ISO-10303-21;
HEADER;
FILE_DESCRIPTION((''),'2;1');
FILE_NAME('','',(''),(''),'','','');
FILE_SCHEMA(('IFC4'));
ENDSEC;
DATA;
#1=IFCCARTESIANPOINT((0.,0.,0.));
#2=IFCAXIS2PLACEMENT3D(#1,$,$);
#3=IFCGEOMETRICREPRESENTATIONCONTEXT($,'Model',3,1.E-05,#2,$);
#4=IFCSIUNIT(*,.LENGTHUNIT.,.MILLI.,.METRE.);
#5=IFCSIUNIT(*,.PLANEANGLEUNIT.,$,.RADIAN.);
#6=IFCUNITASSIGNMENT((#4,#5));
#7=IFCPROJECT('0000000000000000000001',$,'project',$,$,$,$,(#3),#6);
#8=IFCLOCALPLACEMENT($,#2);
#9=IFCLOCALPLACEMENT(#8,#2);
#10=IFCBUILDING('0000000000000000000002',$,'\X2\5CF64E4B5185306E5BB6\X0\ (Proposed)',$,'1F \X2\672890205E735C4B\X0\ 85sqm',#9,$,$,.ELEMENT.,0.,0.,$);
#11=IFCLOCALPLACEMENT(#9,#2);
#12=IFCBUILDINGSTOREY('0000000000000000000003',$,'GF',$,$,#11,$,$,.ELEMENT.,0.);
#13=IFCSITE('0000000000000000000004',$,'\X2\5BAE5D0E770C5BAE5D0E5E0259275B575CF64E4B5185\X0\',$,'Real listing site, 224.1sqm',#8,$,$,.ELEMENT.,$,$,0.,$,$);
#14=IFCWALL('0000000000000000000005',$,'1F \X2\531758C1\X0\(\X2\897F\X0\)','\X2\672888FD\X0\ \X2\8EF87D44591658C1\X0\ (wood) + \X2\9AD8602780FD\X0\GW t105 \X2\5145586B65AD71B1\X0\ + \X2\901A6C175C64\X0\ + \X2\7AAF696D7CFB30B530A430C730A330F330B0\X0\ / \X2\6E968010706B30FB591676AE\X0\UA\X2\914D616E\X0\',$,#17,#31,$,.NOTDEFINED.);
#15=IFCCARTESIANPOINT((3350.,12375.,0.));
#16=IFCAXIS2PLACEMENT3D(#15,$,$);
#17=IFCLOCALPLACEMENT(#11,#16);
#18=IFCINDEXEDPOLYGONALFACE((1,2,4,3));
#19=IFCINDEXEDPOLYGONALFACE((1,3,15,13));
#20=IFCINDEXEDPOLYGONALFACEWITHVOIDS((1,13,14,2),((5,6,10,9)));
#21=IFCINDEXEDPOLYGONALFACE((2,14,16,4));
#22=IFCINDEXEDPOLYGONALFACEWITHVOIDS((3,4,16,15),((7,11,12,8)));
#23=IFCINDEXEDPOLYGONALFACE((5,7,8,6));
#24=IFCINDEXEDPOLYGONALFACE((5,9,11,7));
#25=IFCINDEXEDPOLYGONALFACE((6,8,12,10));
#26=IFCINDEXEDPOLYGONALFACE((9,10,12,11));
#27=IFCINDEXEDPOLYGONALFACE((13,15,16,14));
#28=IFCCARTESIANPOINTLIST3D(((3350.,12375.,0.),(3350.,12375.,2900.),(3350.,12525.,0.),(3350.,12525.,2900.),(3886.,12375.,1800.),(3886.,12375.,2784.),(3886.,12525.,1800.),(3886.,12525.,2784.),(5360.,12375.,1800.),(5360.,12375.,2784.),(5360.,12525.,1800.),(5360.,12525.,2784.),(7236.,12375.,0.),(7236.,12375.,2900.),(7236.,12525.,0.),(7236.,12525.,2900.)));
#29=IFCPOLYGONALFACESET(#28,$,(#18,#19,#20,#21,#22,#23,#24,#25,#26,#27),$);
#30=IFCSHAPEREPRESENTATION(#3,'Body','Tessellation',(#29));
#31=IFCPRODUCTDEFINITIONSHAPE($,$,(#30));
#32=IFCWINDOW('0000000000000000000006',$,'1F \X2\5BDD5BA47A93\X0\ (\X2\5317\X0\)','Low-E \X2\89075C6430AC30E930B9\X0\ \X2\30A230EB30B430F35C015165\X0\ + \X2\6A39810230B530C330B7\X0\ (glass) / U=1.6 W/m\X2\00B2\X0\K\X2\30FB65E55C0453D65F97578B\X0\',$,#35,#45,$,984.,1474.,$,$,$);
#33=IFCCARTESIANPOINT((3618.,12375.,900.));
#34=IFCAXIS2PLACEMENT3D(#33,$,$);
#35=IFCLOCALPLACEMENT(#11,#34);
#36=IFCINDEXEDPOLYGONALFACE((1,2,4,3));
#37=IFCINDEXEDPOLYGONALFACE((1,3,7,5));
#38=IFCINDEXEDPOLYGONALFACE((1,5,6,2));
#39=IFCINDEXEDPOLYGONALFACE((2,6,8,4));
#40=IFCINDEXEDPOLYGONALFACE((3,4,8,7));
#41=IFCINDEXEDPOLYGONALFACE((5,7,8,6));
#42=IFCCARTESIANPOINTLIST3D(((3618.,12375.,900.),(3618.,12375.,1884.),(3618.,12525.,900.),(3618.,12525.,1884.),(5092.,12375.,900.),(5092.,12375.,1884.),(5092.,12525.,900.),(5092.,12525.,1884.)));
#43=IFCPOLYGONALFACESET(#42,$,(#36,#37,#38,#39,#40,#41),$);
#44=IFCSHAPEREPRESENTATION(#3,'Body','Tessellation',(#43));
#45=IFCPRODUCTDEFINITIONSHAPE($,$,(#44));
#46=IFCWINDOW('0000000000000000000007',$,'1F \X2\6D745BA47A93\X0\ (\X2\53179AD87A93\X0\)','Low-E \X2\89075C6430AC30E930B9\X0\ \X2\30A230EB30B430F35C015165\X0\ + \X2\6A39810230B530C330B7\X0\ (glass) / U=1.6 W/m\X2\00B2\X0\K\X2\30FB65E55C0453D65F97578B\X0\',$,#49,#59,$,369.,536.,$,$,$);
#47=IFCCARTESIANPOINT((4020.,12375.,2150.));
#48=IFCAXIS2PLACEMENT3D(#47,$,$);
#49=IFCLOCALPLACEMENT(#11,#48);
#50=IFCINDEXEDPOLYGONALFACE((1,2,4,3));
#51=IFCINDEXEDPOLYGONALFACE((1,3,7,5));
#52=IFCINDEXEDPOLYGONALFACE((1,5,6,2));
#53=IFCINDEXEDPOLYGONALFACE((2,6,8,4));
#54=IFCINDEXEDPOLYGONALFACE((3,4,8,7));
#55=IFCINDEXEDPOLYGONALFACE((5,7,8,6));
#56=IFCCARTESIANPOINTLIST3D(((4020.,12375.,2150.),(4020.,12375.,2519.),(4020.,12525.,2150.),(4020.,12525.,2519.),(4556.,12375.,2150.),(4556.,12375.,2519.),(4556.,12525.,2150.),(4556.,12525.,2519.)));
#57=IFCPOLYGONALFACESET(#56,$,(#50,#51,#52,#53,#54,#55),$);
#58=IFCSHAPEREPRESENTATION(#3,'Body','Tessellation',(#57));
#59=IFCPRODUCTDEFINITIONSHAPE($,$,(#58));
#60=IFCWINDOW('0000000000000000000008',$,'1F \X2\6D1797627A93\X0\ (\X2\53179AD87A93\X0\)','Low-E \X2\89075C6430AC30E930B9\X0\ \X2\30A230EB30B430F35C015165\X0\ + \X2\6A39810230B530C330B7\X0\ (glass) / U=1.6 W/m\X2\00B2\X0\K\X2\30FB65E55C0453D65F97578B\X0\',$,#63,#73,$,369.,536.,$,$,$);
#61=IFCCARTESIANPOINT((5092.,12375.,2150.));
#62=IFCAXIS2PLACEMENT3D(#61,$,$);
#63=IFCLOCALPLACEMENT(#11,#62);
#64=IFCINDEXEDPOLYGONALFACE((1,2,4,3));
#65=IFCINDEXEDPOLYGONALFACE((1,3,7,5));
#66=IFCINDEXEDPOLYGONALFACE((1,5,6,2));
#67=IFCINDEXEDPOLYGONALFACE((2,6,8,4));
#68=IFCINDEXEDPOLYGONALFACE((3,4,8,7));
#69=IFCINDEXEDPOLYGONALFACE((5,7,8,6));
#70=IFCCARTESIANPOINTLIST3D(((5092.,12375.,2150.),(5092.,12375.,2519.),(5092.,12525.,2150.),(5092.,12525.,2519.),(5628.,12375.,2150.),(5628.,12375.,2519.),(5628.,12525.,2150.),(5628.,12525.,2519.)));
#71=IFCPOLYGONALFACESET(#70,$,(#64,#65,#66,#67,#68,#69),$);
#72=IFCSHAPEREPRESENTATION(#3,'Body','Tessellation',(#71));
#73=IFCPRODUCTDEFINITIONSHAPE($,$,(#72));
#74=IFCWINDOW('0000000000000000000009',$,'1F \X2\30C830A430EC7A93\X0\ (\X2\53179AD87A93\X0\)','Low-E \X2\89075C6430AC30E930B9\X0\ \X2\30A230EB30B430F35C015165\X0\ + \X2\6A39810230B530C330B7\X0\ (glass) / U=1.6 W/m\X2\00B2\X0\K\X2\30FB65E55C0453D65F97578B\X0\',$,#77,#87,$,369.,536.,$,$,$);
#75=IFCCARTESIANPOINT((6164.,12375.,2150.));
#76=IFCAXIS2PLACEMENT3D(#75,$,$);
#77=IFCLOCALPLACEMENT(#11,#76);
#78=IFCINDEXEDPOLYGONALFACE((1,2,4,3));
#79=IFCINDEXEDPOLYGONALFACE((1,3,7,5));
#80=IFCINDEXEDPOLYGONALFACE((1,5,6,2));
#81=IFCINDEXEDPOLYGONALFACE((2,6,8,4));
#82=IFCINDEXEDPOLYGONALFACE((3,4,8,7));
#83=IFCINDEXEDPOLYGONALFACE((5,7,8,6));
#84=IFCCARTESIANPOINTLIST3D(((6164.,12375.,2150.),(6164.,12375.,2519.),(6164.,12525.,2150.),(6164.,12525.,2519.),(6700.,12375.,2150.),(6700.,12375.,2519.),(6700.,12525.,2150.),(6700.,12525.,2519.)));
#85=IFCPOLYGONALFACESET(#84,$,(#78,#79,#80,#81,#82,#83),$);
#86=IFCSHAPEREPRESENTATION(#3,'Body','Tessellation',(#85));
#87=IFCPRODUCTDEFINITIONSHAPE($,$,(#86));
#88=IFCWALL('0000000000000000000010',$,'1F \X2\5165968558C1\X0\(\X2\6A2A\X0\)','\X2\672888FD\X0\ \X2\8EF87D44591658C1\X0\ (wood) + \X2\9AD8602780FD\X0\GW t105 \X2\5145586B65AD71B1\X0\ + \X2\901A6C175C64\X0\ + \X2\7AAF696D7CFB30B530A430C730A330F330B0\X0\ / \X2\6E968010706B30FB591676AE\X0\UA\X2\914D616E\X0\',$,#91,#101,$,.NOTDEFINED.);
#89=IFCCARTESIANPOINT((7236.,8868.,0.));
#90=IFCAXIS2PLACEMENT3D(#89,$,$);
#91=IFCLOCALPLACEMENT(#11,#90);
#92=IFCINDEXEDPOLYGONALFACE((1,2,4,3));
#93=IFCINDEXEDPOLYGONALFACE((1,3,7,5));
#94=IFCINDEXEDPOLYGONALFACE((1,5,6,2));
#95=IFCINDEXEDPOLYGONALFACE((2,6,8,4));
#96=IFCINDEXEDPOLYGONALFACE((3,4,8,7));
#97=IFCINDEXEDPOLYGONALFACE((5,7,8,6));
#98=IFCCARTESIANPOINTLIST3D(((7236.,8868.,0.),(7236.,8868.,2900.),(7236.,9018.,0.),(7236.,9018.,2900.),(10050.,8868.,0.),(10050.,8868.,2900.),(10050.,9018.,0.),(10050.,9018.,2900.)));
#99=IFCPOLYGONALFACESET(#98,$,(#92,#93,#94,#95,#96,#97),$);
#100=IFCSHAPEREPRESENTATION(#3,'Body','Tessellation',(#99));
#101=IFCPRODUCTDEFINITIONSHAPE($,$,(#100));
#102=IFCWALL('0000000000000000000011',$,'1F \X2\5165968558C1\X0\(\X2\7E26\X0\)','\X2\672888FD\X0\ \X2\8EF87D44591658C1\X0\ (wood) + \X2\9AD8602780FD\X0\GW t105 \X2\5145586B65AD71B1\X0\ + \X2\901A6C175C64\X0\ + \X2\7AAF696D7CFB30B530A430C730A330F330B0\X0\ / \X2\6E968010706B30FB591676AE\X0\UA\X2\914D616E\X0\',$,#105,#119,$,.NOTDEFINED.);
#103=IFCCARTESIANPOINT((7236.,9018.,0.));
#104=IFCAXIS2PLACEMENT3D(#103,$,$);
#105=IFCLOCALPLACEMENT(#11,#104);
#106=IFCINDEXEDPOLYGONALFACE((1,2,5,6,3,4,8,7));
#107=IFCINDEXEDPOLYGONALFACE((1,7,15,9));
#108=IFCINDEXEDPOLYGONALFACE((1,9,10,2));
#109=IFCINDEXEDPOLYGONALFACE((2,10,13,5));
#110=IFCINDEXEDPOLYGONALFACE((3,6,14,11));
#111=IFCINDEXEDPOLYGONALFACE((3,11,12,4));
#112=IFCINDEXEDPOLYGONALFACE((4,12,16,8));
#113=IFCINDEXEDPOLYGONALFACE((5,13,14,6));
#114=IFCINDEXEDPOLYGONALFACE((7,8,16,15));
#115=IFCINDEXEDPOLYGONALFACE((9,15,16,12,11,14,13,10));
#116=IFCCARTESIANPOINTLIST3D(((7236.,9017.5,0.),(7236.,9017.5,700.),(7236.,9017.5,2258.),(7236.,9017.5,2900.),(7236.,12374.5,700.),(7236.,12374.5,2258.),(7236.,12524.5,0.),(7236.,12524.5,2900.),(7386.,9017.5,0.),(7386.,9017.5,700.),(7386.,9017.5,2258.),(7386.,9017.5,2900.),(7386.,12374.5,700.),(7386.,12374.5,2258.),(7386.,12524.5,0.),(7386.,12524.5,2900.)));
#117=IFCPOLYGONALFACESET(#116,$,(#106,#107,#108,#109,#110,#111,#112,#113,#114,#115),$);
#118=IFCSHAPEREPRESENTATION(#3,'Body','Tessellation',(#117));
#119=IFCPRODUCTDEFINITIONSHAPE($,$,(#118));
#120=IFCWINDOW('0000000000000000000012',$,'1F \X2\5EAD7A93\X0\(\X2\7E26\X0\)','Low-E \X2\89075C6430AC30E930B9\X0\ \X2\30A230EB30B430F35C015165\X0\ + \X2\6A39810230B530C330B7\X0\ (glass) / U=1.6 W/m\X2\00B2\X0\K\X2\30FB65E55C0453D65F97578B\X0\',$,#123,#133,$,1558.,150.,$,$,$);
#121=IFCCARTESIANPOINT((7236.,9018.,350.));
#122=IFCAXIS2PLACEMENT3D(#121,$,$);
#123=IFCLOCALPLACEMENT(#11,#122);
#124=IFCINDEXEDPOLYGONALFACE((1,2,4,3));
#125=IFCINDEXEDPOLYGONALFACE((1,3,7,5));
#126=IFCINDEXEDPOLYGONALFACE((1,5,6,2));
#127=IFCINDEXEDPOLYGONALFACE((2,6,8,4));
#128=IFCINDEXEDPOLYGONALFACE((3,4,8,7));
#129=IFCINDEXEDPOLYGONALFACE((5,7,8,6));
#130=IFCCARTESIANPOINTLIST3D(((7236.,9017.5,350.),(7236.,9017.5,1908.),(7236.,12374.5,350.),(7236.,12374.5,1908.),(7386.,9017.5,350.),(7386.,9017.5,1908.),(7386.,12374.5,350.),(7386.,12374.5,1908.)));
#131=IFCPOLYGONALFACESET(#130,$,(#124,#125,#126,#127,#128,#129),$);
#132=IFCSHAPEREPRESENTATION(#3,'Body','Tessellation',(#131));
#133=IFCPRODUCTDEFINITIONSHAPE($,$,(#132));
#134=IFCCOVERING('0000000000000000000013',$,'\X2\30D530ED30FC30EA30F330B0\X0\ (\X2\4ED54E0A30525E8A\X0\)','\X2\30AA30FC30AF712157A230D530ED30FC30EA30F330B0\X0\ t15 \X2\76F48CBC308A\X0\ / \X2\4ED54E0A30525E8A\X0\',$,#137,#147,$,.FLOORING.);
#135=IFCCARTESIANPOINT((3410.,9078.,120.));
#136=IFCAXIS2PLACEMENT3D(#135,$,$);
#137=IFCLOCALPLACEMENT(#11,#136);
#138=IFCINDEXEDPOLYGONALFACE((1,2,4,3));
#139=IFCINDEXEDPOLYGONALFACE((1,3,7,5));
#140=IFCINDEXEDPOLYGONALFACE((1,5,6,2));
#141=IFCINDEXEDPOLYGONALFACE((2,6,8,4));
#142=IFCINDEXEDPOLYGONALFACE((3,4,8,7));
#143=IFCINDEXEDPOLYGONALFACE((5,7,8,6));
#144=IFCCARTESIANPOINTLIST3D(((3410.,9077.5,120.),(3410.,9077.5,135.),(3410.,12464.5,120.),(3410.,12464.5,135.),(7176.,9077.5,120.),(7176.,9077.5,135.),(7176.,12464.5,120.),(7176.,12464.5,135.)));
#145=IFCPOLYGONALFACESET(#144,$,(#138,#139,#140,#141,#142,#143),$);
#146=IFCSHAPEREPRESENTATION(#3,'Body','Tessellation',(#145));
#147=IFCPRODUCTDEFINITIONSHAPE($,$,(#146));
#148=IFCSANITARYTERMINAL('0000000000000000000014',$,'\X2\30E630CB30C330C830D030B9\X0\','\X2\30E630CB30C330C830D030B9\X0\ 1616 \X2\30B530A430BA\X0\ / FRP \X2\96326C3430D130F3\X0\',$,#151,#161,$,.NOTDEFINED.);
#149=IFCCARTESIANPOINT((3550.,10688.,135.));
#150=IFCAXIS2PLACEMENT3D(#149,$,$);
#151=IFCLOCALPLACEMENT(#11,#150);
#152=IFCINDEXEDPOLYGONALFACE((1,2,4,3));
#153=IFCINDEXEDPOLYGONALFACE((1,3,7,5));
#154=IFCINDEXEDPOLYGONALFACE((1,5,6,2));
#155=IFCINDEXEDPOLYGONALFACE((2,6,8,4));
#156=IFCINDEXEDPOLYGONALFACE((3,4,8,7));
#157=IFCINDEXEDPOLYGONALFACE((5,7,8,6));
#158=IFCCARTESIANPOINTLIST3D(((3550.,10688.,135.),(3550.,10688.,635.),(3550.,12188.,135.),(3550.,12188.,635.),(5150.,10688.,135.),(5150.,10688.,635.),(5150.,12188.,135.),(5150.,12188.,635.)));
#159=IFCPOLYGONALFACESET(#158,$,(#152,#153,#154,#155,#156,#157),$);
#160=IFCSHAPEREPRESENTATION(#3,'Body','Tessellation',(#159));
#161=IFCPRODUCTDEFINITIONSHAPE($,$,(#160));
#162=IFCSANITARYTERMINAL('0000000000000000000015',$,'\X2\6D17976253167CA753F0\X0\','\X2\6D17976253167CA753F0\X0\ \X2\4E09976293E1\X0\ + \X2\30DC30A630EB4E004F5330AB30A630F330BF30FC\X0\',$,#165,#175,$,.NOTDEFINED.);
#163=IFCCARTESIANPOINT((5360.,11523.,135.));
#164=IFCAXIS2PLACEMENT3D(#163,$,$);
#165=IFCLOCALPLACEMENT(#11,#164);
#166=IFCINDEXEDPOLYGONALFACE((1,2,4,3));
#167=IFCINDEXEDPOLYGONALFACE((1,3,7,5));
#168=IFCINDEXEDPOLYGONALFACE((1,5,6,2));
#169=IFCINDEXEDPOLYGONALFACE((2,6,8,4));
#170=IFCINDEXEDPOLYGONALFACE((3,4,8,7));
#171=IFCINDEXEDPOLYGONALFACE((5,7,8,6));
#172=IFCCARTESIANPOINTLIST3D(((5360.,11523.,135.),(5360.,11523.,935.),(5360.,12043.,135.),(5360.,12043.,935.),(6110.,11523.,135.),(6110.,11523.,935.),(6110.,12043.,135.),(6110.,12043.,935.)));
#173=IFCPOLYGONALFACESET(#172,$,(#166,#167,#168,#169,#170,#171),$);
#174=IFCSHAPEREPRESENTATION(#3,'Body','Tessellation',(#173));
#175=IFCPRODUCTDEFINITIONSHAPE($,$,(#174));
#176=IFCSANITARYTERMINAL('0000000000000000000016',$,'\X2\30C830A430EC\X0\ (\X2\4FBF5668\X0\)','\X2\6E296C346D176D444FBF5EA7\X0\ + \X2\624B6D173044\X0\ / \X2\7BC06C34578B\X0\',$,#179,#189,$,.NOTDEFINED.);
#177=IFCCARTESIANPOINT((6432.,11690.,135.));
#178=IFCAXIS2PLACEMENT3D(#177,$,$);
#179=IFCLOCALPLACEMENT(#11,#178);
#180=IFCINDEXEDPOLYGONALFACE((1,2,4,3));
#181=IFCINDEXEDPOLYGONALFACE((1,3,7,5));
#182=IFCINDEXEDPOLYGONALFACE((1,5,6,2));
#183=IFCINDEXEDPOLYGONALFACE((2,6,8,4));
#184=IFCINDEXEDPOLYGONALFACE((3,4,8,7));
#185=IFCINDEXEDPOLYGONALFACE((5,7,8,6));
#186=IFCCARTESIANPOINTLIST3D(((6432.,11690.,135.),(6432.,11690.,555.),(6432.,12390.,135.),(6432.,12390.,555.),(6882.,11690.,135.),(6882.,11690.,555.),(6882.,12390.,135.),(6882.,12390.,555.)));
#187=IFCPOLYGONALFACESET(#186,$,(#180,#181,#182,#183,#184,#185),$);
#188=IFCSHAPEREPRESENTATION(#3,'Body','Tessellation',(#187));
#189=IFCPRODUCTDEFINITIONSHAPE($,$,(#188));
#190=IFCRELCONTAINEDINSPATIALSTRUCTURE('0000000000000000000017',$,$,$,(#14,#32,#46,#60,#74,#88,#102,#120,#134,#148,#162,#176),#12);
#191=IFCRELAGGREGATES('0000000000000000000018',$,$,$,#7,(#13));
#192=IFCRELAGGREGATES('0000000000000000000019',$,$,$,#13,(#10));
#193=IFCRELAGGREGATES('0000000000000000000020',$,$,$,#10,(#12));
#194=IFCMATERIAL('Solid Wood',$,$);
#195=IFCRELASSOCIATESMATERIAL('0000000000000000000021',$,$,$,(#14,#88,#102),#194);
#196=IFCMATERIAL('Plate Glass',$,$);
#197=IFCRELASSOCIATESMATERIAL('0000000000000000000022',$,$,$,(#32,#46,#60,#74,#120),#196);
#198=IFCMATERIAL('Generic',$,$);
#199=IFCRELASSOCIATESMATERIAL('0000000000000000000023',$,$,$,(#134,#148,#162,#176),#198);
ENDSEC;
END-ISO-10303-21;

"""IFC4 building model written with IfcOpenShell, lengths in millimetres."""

from ifc_helpers import new_model, si_unit, frame, frame_2d, origin, place, context, project, spatial, rectangle, extrude, material, element, fill, save


model = new_model("IFC4")

# Units and contexts
model_context = context("Model", 3, precision=1e-05, world=origin())
ifc_project = project(units=[si_unit("LENGTHUNIT", "METRE", prefix="MILLI"), si_unit("PLANEANGLEUNIT", "RADIAN")], contexts=[model_context])

# Site, building, storey
site_placement = place(None, origin())
site = spatial("IfcSite", under=ifc_project, at=site_placement, Name="宮崎県宮崎市大字島之内", ObjectType="Real listing site, 224.1sqm", CompositionType="ELEMENT", RefElevation=0.0)
building_placement = place(site_placement, origin())
building = spatial("IfcBuilding", under=site, at=building_placement, Name="島之内の家 (Proposed)", ObjectType="1F 木造平屋 85sqm", CompositionType="ELEMENT", ElevationOfRefHeight=0.0, ElevationOfTerrain=0.0)
storey_placement = place(building_placement, origin())
storey = spatial("IfcBuildingStorey", under=building, at=storey_placement, Name="GF", CompositionType="ELEMENT", Elevation=0.0)

# Shared definitions
ifc_material_1 = material(Name="Solid Wood")

# Wall, openings, windows
wall_1_placement = place(storey_placement, frame((3350.0, 12375.0, 0.0)))
wall_1 = element("IfcWall", 1, at=wall_1_placement, inside=storey, material=ifc_material_1, Name="1F 北壁(西)", Description="木製 軸組外壁 (wood) + 高性能GW t105 充填断熱 + 通気層 + 窯業系サイディング / 準耐火・外皮UA配慮", PredefinedType="NOTDEFINED", context=model_context, shape_type="SweptSolid", body=[
    extrude(rectangle(XDim=3886.0, YDim=150.0, at=frame_2d((1943.0, 75.0))), frame((3350.0, 12375.0, 0.0)), (0.0, 0.0, 1.0), 2900.0),
])
opening_1_placement = place(storey_placement, frame((3618.0, 12375.0, 900.0)))
opening_1 = element("IfcOpeningElement", 2, at=opening_1_placement, cuts=wall_1, PredefinedType="NOTDEFINED", context=model_context, shape_type="SweptSolid", body=[
    extrude(rectangle(XDim=1474.0, YDim=150.0, at=frame_2d((737.0, 75.0))), frame((3618.0, 12375.0, 900.0)), (0.0, 0.0, 1.0), 984.0),
])
opening_2_placement = place(storey_placement, frame((4020.0, 12375.0, 2150.0)))
opening_2 = element("IfcOpeningElement", 3, at=opening_2_placement, cuts=wall_1, PredefinedType="NOTDEFINED", context=model_context, shape_type="SweptSolid", body=[
    extrude(rectangle(XDim=536.0, YDim=150.0, at=frame_2d((268.0, 75.0))), frame((4020.0, 12375.0, 2150.0)), (0.0, 0.0, 1.0), 369.0),
])
opening_3_placement = place(storey_placement, frame((5092.0, 12375.0, 2150.0)))
opening_3 = element("IfcOpeningElement", 4, at=opening_3_placement, cuts=wall_1, PredefinedType="NOTDEFINED", context=model_context, shape_type="SweptSolid", body=[
    extrude(rectangle(XDim=536.0, YDim=150.0, at=frame_2d((268.0, 75.0))), frame((5092.0, 12375.0, 2150.0)), (0.0, 0.0, 1.0), 369.0),
])
opening_4_placement = place(storey_placement, frame((6164.0, 12375.0, 2150.0)))
opening_4 = element("IfcOpeningElement", 5, at=opening_4_placement, cuts=wall_1, PredefinedType="NOTDEFINED", context=model_context, shape_type="SweptSolid", body=[
    extrude(rectangle(XDim=536.0, YDim=150.0, at=frame_2d((268.0, 75.0))), frame((6164.0, 12375.0, 2150.0)), (0.0, 0.0, 1.0), 369.0),
])
ifc_material_2 = material(Name="Plate Glass")
window_1_placement = place(storey_placement, frame((3618.0, 12375.0, 900.0)))
window_1 = element("IfcWindow", 6, at=window_1_placement, inside=storey, material=ifc_material_2, Name="1F 寝室窓 (北)", Description="Low-E 複層ガラス アルゴン封入 + 樹脂サッシ (glass) / U=1.6 W/m²K・日射取得型", OverallHeight=984.0, OverallWidth=1474.0, context=model_context, shape_type="SweptSolid", body=[
    extrude(rectangle(XDim=1474.0, YDim=150.0, at=frame_2d((737.0, 75.0))), frame((3618.0, 12375.0, 900.0)), (0.0, 0.0, 1.0), 984.0),
])
fill(opening_1, window_1)
window_2_placement = place(storey_placement, frame((4020.0, 12375.0, 2150.0)))
window_2 = element("IfcWindow", 7, at=window_2_placement, inside=storey, material=ifc_material_2, Name="1F 浴室窓 (北高窓)", Description="Low-E 複層ガラス アルゴン封入 + 樹脂サッシ (glass) / U=1.6 W/m²K・日射取得型", OverallHeight=369.0, OverallWidth=536.0, context=model_context, shape_type="SweptSolid", body=[
    extrude(rectangle(XDim=536.0, YDim=150.0, at=frame_2d((268.0, 75.0))), frame((4020.0, 12375.0, 2150.0)), (0.0, 0.0, 1.0), 369.0),
])
fill(opening_2, window_2)
window_3_placement = place(storey_placement, frame((5092.0, 12375.0, 2150.0)))
window_3 = element("IfcWindow", 8, at=window_3_placement, inside=storey, material=ifc_material_2, Name="1F 洗面窓 (北高窓)", Description="Low-E 複層ガラス アルゴン封入 + 樹脂サッシ (glass) / U=1.6 W/m²K・日射取得型", OverallHeight=369.0, OverallWidth=536.0, context=model_context, shape_type="SweptSolid", body=[
    extrude(rectangle(XDim=536.0, YDim=150.0, at=frame_2d((268.0, 75.0))), frame((5092.0, 12375.0, 2150.0)), (0.0, 0.0, 1.0), 369.0),
])
fill(opening_3, window_3)
window_4_placement = place(storey_placement, frame((6164.0, 12375.0, 2150.0)))
window_4 = element("IfcWindow", 9, at=window_4_placement, inside=storey, material=ifc_material_2, Name="1F トイレ窓 (北高窓)", Description="Low-E 複層ガラス アルゴン封入 + 樹脂サッシ (glass) / U=1.6 W/m²K・日射取得型", OverallHeight=369.0, OverallWidth=536.0, context=model_context, shape_type="SweptSolid", body=[
    extrude(rectangle(XDim=536.0, YDim=150.0, at=frame_2d((268.0, 75.0))), frame((6164.0, 12375.0, 2150.0)), (0.0, 0.0, 1.0), 369.0),
])
fill(opening_4, window_4)

# Wall
wall_2_placement = place(storey_placement, frame((7236.0, 8868.0, 0.0)))
element("IfcWall", 10, at=wall_2_placement, inside=storey, material=ifc_material_1, Name="1F 入隅壁(横)", Description="木製 軸組外壁 (wood) + 高性能GW t105 充填断熱 + 通気層 + 窯業系サイディング / 準耐火・外皮UA配慮", PredefinedType="NOTDEFINED", context=model_context, shape_type="SweptSolid", body=[
    extrude(rectangle(XDim=2814.0, YDim=150.0, at=frame_2d((1407.0, 75.0))), frame((7236.0, 8868.0, 0.0)), (0.0, 0.0, 1.0), 2900.0),
])

# Wall, opening, window
wall_3_placement = place(storey_placement, frame((7236.0, 9018.0, 0.0)))
wall_3 = element("IfcWall", 11, at=wall_3_placement, inside=storey, material=ifc_material_1, Name="1F 入隅壁(縦)", Description="木製 軸組外壁 (wood) + 高性能GW t105 充填断熱 + 通気層 + 窯業系サイディング / 準耐火・外皮UA配慮", PredefinedType="NOTDEFINED", context=model_context, shape_type="SweptSolid", body=[
    extrude(rectangle(XDim=150.0, YDim=3507.0, at=frame_2d((75.0, 1753.0))), frame((7236.0, 9018.0, 0.0)), (0.0, 0.0, 1.0), 2900.0),
])
opening_5_placement = place(storey_placement, frame((7236.0, 9018.0, 350.0)))
opening_5 = element("IfcOpeningElement", 12, at=opening_5_placement, cuts=wall_3, PredefinedType="NOTDEFINED", context=model_context, shape_type="SweptSolid", body=[
    extrude(rectangle(XDim=150.0, YDim=3357.0, at=frame_2d((75.0, 1678.0))), frame((7236.0, 9018.0, 350.0)), (0.0, 0.0, 1.0), 1558.0),
])
window_5_placement = place(storey_placement, frame((7236.0, 9018.0, 350.0)))
window_5 = element("IfcWindow", 13, at=window_5_placement, inside=storey, material=ifc_material_2, Name="1F 庭窓(縦)", Description="Low-E 複層ガラス アルゴン封入 + 樹脂サッシ (glass) / U=1.6 W/m²K・日射取得型", OverallHeight=1558.0, OverallWidth=150.0, context=model_context, shape_type="SweptSolid", body=[
    extrude(rectangle(XDim=150.0, YDim=3357.0, at=frame_2d((75.0, 1678.0))), frame((7236.0, 9018.0, 350.0)), (0.0, 0.0, 1.0), 1558.0),
])
fill(opening_5, window_5)

# Covering
ifc_material_3 = material(Name="Generic")
covering_placement = place(storey_placement, frame((3410.0, 9078.0, 120.0)))
element("IfcCovering", 14, at=covering_placement, inside=storey, material=ifc_material_3, Name="フローリング (仕上げ床)", Description="オーク無垢フローリング t15 直貼り / 仕上げ床", PredefinedType="FLOORING", context=model_context, shape_type="SweptSolid", body=[
    extrude(rectangle(XDim=3766.0, YDim=3387.0, at=frame_2d((1883.0, 1693.0))), frame((3410.0, 9078.0, 120.0)), (0.0, 0.0, 1.0), 15.0),
])

# Sanitary terminals
sanitary_terminal_1_placement = place(storey_placement, frame((3550.0, 10688.0, 135.0)))
element("IfcSanitaryTerminal", 15, at=sanitary_terminal_1_placement, inside=storey, material=ifc_material_3, Name="ユニットバス", Description="ユニットバス 1616 サイズ / FRP 防水パン", PredefinedType="NOTDEFINED", context=model_context, shape_type="SweptSolid", body=[
    extrude(rectangle(XDim=1600.0, YDim=1500.0, at=frame_2d((800.0, 750.0))), frame((3550.0, 10688.0, 135.0)), (0.0, 0.0, 1.0), 500.0),
])
sanitary_terminal_2_placement = place(storey_placement, frame((5360.0, 11523.0, 135.0)))
element("IfcSanitaryTerminal", 16, at=sanitary_terminal_2_placement, inside=storey, material=ifc_material_3, Name="洗面化粧台", Description="洗面化粧台 三面鏡 + ボウル一体カウンター", PredefinedType="NOTDEFINED", context=model_context, shape_type="SweptSolid", body=[
    extrude(rectangle(XDim=750.0, YDim=520.0, at=frame_2d((375.0, 260.0))), frame((5360.0, 11523.0, 135.0)), (0.0, 0.0, 1.0), 800.0),
])
sanitary_terminal_3_placement = place(storey_placement, frame((6432.0, 11690.0, 135.0)))
element("IfcSanitaryTerminal", 17, at=sanitary_terminal_3_placement, inside=storey, material=ifc_material_3, Name="トイレ (便器)", Description="温水洗浄便座 + 手洗い / 節水型", PredefinedType="NOTDEFINED", context=model_context, shape_type="SweptSolid", body=[
    extrude(rectangle(XDim=450.0, YDim=700.0, at=frame_2d((225.0, 350.0))), frame((6432.0, 11690.0, 135.0)), (0.0, 0.0, 1.0), 420.0),
])

save(model, "model.ifc")
